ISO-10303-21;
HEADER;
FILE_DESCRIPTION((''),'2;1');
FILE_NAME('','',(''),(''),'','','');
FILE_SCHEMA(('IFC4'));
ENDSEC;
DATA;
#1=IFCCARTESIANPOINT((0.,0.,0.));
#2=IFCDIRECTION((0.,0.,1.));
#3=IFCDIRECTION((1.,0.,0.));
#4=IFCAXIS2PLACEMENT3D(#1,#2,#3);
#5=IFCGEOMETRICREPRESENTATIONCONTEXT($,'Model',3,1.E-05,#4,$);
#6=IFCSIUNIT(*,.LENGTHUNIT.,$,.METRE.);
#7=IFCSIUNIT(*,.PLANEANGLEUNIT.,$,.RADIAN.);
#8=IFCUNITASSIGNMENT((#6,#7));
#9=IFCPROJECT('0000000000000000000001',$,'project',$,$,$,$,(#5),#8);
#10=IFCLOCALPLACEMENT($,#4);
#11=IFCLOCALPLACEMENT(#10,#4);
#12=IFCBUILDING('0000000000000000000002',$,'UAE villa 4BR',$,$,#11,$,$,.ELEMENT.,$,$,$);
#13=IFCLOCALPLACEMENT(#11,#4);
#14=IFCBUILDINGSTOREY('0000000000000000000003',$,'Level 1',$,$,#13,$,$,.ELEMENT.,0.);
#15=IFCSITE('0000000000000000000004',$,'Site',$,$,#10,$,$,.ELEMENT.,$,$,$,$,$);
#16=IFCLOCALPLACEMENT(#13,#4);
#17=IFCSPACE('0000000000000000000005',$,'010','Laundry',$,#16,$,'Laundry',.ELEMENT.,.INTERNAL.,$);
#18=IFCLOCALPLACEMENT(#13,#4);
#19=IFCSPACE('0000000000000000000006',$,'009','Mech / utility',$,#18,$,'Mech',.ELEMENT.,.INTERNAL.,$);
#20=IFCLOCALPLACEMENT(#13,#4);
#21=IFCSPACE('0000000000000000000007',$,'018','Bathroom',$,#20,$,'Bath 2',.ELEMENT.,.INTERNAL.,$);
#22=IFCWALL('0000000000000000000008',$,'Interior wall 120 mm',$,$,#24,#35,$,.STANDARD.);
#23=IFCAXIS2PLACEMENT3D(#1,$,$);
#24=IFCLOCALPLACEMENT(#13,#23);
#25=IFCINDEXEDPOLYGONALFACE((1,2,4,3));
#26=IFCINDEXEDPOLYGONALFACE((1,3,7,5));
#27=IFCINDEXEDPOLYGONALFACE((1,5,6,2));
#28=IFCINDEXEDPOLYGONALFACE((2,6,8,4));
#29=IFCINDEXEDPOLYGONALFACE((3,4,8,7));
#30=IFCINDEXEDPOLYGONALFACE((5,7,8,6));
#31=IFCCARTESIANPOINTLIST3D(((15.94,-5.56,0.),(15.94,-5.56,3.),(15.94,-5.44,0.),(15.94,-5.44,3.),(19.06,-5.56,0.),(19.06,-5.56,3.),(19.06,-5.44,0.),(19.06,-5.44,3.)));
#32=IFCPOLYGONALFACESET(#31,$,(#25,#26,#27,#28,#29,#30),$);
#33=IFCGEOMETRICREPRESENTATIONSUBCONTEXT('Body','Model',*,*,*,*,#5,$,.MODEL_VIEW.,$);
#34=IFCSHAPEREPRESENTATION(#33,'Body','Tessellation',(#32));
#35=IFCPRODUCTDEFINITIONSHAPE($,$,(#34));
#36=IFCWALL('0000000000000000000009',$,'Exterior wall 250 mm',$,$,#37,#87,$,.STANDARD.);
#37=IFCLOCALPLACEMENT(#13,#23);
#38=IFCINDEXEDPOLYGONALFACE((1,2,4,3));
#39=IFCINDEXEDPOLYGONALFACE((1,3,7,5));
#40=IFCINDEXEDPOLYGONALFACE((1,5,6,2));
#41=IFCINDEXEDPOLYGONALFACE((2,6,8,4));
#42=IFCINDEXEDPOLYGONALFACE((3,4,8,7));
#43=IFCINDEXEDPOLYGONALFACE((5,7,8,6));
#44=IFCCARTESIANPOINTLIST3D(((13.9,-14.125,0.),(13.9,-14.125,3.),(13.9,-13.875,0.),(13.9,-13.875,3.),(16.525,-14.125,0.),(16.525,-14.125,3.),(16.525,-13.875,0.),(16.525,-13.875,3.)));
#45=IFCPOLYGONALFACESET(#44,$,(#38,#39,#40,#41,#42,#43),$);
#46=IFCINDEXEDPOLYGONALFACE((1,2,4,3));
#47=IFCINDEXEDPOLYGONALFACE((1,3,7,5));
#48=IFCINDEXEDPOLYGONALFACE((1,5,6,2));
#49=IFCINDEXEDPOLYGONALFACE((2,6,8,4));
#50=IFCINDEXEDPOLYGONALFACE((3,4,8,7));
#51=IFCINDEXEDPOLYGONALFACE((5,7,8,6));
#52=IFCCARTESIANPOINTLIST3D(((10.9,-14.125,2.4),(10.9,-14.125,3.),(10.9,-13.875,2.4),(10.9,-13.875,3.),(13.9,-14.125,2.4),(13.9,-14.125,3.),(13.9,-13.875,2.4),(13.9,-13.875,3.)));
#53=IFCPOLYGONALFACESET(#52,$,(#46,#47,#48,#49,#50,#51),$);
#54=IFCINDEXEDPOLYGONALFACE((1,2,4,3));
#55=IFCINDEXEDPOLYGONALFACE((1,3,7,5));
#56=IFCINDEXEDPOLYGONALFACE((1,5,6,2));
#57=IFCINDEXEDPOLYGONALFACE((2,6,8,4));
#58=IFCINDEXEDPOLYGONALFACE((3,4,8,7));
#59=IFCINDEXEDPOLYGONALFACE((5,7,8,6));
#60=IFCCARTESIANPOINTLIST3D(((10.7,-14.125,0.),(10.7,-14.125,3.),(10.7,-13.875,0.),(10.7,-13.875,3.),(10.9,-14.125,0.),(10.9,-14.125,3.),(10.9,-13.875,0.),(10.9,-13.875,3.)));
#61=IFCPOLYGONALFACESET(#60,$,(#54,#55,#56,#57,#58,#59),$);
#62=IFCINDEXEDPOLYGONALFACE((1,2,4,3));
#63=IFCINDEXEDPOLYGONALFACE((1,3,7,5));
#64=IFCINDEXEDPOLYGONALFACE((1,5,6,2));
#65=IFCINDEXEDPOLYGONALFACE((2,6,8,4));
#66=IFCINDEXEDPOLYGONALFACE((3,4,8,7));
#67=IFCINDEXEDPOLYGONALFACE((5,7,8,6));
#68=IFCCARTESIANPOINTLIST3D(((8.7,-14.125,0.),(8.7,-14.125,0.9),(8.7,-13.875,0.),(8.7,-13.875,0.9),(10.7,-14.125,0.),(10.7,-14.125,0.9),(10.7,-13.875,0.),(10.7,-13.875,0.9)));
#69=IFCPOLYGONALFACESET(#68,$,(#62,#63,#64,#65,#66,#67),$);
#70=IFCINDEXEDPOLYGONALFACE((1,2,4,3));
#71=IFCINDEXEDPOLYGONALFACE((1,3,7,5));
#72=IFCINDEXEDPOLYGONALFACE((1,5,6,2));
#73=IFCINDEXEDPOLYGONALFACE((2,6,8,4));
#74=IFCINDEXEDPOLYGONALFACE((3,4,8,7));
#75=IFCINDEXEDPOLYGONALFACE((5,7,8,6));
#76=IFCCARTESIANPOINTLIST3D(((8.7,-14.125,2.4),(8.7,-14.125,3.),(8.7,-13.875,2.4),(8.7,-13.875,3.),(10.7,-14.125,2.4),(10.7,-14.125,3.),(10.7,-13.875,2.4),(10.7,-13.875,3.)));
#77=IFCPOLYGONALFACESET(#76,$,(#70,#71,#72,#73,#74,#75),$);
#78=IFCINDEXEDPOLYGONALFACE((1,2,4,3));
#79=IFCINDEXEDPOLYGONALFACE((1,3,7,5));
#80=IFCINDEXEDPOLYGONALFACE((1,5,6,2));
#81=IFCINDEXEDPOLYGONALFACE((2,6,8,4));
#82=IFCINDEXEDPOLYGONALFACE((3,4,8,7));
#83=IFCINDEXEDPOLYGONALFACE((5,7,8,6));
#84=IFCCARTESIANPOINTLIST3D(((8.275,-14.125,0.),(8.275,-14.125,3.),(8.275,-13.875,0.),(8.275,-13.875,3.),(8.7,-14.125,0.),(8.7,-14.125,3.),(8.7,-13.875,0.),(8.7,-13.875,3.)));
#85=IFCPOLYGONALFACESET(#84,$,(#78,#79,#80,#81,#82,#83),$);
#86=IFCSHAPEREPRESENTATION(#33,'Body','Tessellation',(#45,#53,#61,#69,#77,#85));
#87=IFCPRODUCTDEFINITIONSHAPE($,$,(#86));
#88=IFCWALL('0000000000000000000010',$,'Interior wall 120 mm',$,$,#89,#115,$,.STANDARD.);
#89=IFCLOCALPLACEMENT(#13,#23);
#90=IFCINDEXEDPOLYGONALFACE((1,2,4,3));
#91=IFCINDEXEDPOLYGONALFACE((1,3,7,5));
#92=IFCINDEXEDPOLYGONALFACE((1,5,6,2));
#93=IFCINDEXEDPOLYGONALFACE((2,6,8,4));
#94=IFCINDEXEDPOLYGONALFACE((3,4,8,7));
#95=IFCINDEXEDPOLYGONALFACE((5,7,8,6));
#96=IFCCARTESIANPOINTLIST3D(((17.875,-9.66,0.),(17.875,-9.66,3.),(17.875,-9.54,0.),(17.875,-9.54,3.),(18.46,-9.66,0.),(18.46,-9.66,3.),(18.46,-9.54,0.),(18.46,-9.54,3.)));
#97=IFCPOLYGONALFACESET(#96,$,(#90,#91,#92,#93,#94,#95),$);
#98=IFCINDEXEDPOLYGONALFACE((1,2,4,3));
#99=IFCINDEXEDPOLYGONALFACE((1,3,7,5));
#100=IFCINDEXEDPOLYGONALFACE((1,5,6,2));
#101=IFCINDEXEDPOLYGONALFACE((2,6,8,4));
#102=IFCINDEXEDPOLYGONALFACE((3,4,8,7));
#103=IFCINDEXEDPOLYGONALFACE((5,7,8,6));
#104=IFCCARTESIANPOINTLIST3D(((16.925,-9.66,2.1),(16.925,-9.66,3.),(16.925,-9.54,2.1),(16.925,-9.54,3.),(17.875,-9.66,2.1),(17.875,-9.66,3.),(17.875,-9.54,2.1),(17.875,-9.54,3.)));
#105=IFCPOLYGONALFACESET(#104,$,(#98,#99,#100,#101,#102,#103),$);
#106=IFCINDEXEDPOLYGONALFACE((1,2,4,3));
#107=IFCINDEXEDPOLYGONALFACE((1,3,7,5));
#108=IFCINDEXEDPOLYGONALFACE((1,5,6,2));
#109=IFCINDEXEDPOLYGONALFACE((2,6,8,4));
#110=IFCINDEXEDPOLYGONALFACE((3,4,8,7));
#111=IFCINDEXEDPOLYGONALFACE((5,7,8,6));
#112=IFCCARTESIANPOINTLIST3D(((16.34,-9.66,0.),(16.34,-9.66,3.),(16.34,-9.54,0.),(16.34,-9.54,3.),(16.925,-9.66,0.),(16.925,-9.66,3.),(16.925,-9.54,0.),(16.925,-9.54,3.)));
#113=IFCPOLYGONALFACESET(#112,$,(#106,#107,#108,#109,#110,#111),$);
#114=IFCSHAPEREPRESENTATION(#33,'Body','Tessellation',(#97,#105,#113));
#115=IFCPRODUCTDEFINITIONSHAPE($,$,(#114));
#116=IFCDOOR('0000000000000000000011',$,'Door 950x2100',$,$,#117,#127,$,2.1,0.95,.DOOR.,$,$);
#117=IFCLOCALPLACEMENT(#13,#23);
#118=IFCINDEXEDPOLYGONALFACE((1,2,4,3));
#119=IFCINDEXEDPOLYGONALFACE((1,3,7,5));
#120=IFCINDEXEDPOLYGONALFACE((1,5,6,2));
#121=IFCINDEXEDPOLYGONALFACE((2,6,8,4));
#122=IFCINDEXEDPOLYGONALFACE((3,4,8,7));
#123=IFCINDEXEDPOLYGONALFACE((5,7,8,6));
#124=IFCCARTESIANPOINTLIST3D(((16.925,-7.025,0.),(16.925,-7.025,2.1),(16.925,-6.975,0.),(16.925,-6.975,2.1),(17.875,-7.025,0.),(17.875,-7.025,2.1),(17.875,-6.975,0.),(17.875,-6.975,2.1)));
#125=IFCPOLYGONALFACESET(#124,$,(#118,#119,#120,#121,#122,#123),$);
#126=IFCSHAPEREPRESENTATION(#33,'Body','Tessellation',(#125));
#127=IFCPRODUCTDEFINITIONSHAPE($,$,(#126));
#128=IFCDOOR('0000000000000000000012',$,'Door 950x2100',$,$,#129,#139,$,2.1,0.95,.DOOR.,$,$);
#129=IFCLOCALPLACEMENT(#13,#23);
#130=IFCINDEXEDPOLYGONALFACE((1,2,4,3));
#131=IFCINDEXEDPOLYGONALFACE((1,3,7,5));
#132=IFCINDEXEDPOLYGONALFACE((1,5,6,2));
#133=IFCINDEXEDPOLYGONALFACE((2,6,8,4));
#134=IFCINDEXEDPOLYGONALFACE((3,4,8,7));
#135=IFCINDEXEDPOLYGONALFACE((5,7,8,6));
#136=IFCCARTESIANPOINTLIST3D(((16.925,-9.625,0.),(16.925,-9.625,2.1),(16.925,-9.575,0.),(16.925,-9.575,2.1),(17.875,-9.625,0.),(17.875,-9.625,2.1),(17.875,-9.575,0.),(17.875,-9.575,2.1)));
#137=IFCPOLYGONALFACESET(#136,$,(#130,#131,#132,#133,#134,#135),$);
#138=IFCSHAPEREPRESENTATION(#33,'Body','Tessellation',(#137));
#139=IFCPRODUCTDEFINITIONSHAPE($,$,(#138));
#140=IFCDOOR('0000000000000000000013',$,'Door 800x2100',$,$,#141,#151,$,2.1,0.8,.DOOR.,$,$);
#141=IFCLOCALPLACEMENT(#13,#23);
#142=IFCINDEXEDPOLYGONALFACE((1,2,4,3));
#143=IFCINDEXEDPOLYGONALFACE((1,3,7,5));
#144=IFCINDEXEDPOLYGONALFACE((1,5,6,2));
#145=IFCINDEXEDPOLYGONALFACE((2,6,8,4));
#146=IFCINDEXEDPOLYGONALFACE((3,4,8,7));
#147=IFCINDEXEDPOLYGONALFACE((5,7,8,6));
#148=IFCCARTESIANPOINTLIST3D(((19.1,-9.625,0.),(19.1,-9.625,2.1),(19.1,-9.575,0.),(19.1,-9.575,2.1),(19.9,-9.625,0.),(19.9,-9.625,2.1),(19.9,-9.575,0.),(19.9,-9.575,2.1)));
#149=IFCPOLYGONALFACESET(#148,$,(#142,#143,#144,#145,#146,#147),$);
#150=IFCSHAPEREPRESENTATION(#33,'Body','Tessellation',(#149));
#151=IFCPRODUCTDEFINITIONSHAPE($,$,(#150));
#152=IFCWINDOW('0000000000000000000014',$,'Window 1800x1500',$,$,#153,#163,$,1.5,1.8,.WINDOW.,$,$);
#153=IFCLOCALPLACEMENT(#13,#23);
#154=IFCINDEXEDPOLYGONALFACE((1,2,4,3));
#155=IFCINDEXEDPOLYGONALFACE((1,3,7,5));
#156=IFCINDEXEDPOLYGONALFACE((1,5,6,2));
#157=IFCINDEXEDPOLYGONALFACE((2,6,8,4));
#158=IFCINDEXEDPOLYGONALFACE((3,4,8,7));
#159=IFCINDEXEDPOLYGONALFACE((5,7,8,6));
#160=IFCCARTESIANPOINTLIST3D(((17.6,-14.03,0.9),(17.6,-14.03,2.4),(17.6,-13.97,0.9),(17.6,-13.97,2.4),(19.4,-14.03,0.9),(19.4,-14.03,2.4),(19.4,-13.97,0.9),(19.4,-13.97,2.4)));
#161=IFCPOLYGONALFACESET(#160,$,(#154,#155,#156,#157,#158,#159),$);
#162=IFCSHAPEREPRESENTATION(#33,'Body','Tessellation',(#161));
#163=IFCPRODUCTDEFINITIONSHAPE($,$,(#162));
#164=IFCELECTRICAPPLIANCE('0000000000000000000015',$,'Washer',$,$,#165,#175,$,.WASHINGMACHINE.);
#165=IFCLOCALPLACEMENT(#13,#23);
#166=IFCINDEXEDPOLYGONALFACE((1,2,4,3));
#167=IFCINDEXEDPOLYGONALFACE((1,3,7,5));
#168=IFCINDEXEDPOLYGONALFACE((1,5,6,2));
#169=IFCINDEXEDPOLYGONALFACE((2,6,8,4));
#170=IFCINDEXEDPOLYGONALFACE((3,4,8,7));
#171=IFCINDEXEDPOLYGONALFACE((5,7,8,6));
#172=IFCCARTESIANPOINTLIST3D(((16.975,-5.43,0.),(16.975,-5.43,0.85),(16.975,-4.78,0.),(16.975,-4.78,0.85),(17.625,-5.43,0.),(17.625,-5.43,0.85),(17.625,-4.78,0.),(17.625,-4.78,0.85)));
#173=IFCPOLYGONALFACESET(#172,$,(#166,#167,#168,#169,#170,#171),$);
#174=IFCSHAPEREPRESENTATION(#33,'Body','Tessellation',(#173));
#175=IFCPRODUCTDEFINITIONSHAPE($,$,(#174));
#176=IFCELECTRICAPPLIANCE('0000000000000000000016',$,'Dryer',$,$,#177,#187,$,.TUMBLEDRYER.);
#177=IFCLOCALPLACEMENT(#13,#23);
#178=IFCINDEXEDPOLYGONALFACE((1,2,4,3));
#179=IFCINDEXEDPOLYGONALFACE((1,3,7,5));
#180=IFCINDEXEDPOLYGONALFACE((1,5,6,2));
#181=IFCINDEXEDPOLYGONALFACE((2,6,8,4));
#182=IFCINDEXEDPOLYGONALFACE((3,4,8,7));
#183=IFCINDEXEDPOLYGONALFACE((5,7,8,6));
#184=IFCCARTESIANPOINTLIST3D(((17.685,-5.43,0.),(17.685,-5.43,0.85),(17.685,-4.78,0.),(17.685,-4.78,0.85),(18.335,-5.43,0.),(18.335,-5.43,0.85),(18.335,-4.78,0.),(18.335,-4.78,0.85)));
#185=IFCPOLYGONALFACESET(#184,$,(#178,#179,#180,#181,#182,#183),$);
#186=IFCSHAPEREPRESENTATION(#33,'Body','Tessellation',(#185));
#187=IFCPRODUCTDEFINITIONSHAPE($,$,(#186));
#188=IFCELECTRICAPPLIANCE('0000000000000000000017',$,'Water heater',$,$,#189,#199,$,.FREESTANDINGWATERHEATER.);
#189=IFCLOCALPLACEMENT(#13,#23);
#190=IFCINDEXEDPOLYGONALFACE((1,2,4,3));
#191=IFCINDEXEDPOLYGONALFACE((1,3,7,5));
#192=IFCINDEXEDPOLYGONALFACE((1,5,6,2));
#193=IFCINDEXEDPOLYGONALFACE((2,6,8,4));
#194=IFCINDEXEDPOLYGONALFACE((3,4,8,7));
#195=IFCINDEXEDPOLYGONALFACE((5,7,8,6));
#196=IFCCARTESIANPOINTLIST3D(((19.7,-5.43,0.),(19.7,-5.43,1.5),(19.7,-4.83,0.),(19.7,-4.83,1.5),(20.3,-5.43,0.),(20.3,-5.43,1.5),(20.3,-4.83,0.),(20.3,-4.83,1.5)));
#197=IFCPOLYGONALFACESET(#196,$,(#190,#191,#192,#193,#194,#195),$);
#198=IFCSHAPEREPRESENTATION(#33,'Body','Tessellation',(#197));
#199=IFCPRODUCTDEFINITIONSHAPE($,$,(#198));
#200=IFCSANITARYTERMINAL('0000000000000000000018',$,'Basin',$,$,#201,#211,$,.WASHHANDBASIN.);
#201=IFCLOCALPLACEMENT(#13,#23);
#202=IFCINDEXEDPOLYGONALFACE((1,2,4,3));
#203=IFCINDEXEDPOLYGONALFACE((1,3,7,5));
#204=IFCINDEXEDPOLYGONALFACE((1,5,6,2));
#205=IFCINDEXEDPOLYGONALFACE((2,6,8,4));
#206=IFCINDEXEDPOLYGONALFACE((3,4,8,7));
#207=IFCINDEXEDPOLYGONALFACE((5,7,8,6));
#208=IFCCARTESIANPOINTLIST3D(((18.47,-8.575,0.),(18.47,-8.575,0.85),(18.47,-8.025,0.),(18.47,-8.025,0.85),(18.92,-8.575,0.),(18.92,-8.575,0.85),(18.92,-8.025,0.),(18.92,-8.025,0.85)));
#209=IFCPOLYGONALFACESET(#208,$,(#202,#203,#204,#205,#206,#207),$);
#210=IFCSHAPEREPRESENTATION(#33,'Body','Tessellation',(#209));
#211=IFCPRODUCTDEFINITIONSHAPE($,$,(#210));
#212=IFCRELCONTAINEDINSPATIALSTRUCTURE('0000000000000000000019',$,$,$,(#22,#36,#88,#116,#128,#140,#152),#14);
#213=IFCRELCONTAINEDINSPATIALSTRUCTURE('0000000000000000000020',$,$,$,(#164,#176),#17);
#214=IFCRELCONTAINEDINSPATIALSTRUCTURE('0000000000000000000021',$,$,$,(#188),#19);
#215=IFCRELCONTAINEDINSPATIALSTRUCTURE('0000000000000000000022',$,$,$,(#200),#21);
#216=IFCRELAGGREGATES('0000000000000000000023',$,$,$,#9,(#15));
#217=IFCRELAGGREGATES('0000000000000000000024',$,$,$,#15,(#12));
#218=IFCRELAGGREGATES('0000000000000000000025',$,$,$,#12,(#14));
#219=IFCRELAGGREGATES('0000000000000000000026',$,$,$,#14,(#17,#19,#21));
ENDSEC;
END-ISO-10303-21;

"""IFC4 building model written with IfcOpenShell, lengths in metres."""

from ifc_helpers import new_model, si_unit, frame, origin, origin_with_axes, origin_2d, place, context, subcontext, project, spatial, rectangle, extrude, element, save


model = new_model("IFC4")

# Units and contexts
model_context = context("Model", 3, precision=1e-05, world=origin_with_axes())
body_context = subcontext(model_context, "Body", "Model", "MODEL_VIEW")
ifc_project = project(units=[si_unit("LENGTHUNIT", "METRE"), si_unit("PLANEANGLEUNIT", "RADIAN")], contexts=[model_context])

# Site, building, storey
site_placement = place(None, origin_with_axes())
site = spatial("IfcSite", under=ifc_project, at=site_placement, Name="Site", CompositionType="ELEMENT")
building_placement = place(site_placement, origin_with_axes())
building = spatial("IfcBuilding", under=site, at=building_placement, Name="UAE villa 4BR", CompositionType="ELEMENT")
storey_placement = place(building_placement, origin_with_axes())
storey = spatial("IfcBuildingStorey", under=building, at=storey_placement, Name="Level 1", CompositionType="ELEMENT", Elevation=0.0)

# Walls
wall_1_placement = place(storey_placement, frame((19.0, -5.5, 0.0), z_axis=(0.0, 0.0, 1.0), x_axis=(-1.0, 0.0, 0.0)))
element("IfcWall", 1, at=wall_1_placement, inside=storey, Name="Interior wall 120 mm", PredefinedType="STANDARD", context=body_context, shape_type="SweptSolid", body=[
    extrude(rectangle(XDim=3.12, YDim=0.12, at=origin_2d()), frame((1.5, 0.0, 0.0)), (0.0, 0.0, 1.0), 3.0),
])
wall_2_placement = place(storey_placement, frame((16.4, -14.0, 0.0), z_axis=(0.0, 0.0, 1.0), x_axis=(-1.0, 0.0, 0.0)))
element("IfcWall", 2, at=wall_2_placement, inside=storey, Name="Exterior wall 250 mm", PredefinedType="STANDARD", context=body_context, shape_type="SweptSolid", body=[
    extrude(rectangle(XDim=2.625, YDim=0.25, at=origin_2d()), frame((1.1875, 0.0, 0.0)), (0.0, 0.0, 1.0), 3.0),
    extrude(rectangle(XDim=3.0, YDim=0.25, at=origin_2d()), frame((4.0, 0.0, 2.4)), (0.0, 0.0, 1.0), 0.6),
    extrude(rectangle(XDim=0.2, YDim=0.25, at=origin_2d()), frame((5.6, 0.0, 0.0)), (0.0, 0.0, 1.0), 3.0),
    extrude(rectangle(XDim=2.0, YDim=0.25, at=origin_2d()), frame((6.7, 0.0, 0.0)), (0.0, 0.0, 1.0), 0.9),
    extrude(rectangle(XDim=2.0, YDim=0.25, at=origin_2d()), frame((6.7, 0.0, 2.4)), (0.0, 0.0, 1.0), 0.6),
    extrude(rectangle(XDim=0.425, YDim=0.25, at=origin_2d()), frame((7.9125, 0.0, 0.0)), (0.0, 0.0, 1.0), 3.0),
])
wall_3_placement = place(storey_placement, frame((18.4, -9.6, 0.0), z_axis=(0.0, 0.0, 1.0), x_axis=(-1.0, 0.0, 0.0)))
element("IfcWall", 3, at=wall_3_placement, inside=storey, Name="Interior wall 120 mm", PredefinedType="STANDARD", context=body_context, shape_type="SweptSolid", body=[
    extrude(rectangle(XDim=0.585, YDim=0.12, at=origin_2d()), frame((0.2325, 0.0, 0.0)), (0.0, 0.0, 1.0), 3.0),
    extrude(rectangle(XDim=0.95, YDim=0.12, at=origin_2d()), frame((1.0, 0.0, 2.1)), (0.0, 0.0, 1.0), 0.9),
    extrude(rectangle(XDim=0.585, YDim=0.12, at=origin_2d()), frame((1.7675, 0.0, 0.0)), (0.0, 0.0, 1.0), 3.0),
])

# Doors
for number, where, z_axis, x_axis, name in (
    (4, (17.4, -7.0, 0.0), (0.0, 0.0, 1.0), (-1.0, 0.0, 0.0), "Door 950x2100"),
    (5, (17.4, -9.6, 0.0), (0.0, 0.0, 1.0), (-1.0, 0.0, 0.0), "Door 950x2100"),
):
    element("IfcDoor", number, at=place(storey_placement, frame(where, z_axis=z_axis, x_axis=x_axis)), inside=storey, Name=name, OverallHeight=2.1, OverallWidth=0.95, PredefinedType="DOOR", context=body_context, shape_type="SweptSolid", body=[
        extrude(rectangle(XDim=0.95, YDim=0.05, at=origin_2d()), origin(), (0.0, 0.0, 1.0), 2.1),
    ])
door_placement = place(storey_placement, frame((19.5, -9.6, 0.0), z_axis=(0.0, 0.0, 1.0), x_axis=(-1.0, 0.0, 0.0)))
element("IfcDoor", 6, at=door_placement, inside=storey, Name="Door 800x2100", OverallHeight=2.1, OverallWidth=0.8, PredefinedType="DOOR", context=body_context, shape_type="SweptSolid", body=[
    extrude(rectangle(XDim=0.8, YDim=0.05, at=origin_2d()), origin(), (0.0, 0.0, 1.0), 2.1),
])

# Window
window_placement = place(storey_placement, frame((18.5, -14.0, 0.9), z_axis=(0.0, 0.0, 1.0), x_axis=(-1.0, 0.0, 0.0)))
element("IfcWindow", 7, at=window_placement, inside=storey, Name="Window 1800x1500", OverallHeight=1.5, OverallWidth=1.8, PredefinedType="WINDOW", context=body_context, shape_type="SweptSolid", body=[
    extrude(rectangle(XDim=1.8, YDim=0.06, at=origin_2d()), origin(), (0.0, 0.0, 1.0), 1.5),
])

# Shared definitions
space_1_placement = place(storey_placement, origin_with_axes())
space_1 = spatial("IfcSpace", under=storey, at=space_1_placement, Name="010", Description="Laundry", LongName="Laundry", CompositionType="ELEMENT", PredefinedType="INTERNAL")

# Electric appliances
electric_appliance_1_placement = place(storey_placement, frame((17.3, -5.105, 0.0), z_axis=(0.0, 0.0, 1.0), x_axis=(-1.0, 0.0, 0.0)))
element("IfcElectricAppliance", 8, at=electric_appliance_1_placement, inside=space_1, Name="Washer", PredefinedType="WASHINGMACHINE", context=body_context, shape_type="SweptSolid", body=[
    extrude(rectangle(XDim=0.65, YDim=0.65, at=origin_2d()), origin(), (0.0, 0.0, 1.0), 0.85),
])
electric_appliance_2_placement = place(storey_placement, frame((18.01, -5.105, 0.0), z_axis=(0.0, 0.0, 1.0), x_axis=(-1.0, 0.0, 0.0)))
element("IfcElectricAppliance", 9, at=electric_appliance_2_placement, inside=space_1, Name="Dryer", PredefinedType="TUMBLEDRYER", context=body_context, shape_type="SweptSolid", body=[
    extrude(rectangle(XDim=0.65, YDim=0.65, at=origin_2d()), origin(), (0.0, 0.0, 1.0), 0.85),
])

# Shared definitions
space_2_placement = place(storey_placement, origin_with_axes())
space_2 = spatial("IfcSpace", under=storey, at=space_2_placement, Name="009", Description="Mech / utility", LongName="Mech", CompositionType="ELEMENT", PredefinedType="INTERNAL")

# Electric appliance
electric_appliance_3_placement = place(storey_placement, frame((20.0, -5.13, 0.0), z_axis=(0.0, 0.0, 1.0), x_axis=(-1.0, 0.0, 0.0)))
element("IfcElectricAppliance", 10, at=electric_appliance_3_placement, inside=space_2, Name="Water heater", PredefinedType="FREESTANDINGWATERHEATER", context=body_context, shape_type="SweptSolid", body=[
    extrude(rectangle(XDim=0.6, YDim=0.6, at=origin_2d()), origin(), (0.0, 0.0, 1.0), 1.5),
])

# Shared definitions
space_3_placement = place(storey_placement, origin_with_axes())
space_3 = spatial("IfcSpace", under=storey, at=space_3_placement, Name="018", Description="Bathroom", LongName="Bath 2", CompositionType="ELEMENT", PredefinedType="INTERNAL")

# Sanitary terminal
sanitary_terminal_placement = place(storey_placement, frame((18.695, -8.3, 0.0), z_axis=(0.0, 0.0, 1.0), x_axis=(0.0, 1.0, 0.0)))
element("IfcSanitaryTerminal", 11, at=sanitary_terminal_placement, inside=space_3, Name="Basin", PredefinedType="WASHHANDBASIN", context=body_context, shape_type="SweptSolid", body=[
    extrude(rectangle(XDim=0.55, YDim=0.45, at=origin_2d()), origin(), (0.0, 0.0, 1.0), 0.85),
])

save(model, "model.ifc")
